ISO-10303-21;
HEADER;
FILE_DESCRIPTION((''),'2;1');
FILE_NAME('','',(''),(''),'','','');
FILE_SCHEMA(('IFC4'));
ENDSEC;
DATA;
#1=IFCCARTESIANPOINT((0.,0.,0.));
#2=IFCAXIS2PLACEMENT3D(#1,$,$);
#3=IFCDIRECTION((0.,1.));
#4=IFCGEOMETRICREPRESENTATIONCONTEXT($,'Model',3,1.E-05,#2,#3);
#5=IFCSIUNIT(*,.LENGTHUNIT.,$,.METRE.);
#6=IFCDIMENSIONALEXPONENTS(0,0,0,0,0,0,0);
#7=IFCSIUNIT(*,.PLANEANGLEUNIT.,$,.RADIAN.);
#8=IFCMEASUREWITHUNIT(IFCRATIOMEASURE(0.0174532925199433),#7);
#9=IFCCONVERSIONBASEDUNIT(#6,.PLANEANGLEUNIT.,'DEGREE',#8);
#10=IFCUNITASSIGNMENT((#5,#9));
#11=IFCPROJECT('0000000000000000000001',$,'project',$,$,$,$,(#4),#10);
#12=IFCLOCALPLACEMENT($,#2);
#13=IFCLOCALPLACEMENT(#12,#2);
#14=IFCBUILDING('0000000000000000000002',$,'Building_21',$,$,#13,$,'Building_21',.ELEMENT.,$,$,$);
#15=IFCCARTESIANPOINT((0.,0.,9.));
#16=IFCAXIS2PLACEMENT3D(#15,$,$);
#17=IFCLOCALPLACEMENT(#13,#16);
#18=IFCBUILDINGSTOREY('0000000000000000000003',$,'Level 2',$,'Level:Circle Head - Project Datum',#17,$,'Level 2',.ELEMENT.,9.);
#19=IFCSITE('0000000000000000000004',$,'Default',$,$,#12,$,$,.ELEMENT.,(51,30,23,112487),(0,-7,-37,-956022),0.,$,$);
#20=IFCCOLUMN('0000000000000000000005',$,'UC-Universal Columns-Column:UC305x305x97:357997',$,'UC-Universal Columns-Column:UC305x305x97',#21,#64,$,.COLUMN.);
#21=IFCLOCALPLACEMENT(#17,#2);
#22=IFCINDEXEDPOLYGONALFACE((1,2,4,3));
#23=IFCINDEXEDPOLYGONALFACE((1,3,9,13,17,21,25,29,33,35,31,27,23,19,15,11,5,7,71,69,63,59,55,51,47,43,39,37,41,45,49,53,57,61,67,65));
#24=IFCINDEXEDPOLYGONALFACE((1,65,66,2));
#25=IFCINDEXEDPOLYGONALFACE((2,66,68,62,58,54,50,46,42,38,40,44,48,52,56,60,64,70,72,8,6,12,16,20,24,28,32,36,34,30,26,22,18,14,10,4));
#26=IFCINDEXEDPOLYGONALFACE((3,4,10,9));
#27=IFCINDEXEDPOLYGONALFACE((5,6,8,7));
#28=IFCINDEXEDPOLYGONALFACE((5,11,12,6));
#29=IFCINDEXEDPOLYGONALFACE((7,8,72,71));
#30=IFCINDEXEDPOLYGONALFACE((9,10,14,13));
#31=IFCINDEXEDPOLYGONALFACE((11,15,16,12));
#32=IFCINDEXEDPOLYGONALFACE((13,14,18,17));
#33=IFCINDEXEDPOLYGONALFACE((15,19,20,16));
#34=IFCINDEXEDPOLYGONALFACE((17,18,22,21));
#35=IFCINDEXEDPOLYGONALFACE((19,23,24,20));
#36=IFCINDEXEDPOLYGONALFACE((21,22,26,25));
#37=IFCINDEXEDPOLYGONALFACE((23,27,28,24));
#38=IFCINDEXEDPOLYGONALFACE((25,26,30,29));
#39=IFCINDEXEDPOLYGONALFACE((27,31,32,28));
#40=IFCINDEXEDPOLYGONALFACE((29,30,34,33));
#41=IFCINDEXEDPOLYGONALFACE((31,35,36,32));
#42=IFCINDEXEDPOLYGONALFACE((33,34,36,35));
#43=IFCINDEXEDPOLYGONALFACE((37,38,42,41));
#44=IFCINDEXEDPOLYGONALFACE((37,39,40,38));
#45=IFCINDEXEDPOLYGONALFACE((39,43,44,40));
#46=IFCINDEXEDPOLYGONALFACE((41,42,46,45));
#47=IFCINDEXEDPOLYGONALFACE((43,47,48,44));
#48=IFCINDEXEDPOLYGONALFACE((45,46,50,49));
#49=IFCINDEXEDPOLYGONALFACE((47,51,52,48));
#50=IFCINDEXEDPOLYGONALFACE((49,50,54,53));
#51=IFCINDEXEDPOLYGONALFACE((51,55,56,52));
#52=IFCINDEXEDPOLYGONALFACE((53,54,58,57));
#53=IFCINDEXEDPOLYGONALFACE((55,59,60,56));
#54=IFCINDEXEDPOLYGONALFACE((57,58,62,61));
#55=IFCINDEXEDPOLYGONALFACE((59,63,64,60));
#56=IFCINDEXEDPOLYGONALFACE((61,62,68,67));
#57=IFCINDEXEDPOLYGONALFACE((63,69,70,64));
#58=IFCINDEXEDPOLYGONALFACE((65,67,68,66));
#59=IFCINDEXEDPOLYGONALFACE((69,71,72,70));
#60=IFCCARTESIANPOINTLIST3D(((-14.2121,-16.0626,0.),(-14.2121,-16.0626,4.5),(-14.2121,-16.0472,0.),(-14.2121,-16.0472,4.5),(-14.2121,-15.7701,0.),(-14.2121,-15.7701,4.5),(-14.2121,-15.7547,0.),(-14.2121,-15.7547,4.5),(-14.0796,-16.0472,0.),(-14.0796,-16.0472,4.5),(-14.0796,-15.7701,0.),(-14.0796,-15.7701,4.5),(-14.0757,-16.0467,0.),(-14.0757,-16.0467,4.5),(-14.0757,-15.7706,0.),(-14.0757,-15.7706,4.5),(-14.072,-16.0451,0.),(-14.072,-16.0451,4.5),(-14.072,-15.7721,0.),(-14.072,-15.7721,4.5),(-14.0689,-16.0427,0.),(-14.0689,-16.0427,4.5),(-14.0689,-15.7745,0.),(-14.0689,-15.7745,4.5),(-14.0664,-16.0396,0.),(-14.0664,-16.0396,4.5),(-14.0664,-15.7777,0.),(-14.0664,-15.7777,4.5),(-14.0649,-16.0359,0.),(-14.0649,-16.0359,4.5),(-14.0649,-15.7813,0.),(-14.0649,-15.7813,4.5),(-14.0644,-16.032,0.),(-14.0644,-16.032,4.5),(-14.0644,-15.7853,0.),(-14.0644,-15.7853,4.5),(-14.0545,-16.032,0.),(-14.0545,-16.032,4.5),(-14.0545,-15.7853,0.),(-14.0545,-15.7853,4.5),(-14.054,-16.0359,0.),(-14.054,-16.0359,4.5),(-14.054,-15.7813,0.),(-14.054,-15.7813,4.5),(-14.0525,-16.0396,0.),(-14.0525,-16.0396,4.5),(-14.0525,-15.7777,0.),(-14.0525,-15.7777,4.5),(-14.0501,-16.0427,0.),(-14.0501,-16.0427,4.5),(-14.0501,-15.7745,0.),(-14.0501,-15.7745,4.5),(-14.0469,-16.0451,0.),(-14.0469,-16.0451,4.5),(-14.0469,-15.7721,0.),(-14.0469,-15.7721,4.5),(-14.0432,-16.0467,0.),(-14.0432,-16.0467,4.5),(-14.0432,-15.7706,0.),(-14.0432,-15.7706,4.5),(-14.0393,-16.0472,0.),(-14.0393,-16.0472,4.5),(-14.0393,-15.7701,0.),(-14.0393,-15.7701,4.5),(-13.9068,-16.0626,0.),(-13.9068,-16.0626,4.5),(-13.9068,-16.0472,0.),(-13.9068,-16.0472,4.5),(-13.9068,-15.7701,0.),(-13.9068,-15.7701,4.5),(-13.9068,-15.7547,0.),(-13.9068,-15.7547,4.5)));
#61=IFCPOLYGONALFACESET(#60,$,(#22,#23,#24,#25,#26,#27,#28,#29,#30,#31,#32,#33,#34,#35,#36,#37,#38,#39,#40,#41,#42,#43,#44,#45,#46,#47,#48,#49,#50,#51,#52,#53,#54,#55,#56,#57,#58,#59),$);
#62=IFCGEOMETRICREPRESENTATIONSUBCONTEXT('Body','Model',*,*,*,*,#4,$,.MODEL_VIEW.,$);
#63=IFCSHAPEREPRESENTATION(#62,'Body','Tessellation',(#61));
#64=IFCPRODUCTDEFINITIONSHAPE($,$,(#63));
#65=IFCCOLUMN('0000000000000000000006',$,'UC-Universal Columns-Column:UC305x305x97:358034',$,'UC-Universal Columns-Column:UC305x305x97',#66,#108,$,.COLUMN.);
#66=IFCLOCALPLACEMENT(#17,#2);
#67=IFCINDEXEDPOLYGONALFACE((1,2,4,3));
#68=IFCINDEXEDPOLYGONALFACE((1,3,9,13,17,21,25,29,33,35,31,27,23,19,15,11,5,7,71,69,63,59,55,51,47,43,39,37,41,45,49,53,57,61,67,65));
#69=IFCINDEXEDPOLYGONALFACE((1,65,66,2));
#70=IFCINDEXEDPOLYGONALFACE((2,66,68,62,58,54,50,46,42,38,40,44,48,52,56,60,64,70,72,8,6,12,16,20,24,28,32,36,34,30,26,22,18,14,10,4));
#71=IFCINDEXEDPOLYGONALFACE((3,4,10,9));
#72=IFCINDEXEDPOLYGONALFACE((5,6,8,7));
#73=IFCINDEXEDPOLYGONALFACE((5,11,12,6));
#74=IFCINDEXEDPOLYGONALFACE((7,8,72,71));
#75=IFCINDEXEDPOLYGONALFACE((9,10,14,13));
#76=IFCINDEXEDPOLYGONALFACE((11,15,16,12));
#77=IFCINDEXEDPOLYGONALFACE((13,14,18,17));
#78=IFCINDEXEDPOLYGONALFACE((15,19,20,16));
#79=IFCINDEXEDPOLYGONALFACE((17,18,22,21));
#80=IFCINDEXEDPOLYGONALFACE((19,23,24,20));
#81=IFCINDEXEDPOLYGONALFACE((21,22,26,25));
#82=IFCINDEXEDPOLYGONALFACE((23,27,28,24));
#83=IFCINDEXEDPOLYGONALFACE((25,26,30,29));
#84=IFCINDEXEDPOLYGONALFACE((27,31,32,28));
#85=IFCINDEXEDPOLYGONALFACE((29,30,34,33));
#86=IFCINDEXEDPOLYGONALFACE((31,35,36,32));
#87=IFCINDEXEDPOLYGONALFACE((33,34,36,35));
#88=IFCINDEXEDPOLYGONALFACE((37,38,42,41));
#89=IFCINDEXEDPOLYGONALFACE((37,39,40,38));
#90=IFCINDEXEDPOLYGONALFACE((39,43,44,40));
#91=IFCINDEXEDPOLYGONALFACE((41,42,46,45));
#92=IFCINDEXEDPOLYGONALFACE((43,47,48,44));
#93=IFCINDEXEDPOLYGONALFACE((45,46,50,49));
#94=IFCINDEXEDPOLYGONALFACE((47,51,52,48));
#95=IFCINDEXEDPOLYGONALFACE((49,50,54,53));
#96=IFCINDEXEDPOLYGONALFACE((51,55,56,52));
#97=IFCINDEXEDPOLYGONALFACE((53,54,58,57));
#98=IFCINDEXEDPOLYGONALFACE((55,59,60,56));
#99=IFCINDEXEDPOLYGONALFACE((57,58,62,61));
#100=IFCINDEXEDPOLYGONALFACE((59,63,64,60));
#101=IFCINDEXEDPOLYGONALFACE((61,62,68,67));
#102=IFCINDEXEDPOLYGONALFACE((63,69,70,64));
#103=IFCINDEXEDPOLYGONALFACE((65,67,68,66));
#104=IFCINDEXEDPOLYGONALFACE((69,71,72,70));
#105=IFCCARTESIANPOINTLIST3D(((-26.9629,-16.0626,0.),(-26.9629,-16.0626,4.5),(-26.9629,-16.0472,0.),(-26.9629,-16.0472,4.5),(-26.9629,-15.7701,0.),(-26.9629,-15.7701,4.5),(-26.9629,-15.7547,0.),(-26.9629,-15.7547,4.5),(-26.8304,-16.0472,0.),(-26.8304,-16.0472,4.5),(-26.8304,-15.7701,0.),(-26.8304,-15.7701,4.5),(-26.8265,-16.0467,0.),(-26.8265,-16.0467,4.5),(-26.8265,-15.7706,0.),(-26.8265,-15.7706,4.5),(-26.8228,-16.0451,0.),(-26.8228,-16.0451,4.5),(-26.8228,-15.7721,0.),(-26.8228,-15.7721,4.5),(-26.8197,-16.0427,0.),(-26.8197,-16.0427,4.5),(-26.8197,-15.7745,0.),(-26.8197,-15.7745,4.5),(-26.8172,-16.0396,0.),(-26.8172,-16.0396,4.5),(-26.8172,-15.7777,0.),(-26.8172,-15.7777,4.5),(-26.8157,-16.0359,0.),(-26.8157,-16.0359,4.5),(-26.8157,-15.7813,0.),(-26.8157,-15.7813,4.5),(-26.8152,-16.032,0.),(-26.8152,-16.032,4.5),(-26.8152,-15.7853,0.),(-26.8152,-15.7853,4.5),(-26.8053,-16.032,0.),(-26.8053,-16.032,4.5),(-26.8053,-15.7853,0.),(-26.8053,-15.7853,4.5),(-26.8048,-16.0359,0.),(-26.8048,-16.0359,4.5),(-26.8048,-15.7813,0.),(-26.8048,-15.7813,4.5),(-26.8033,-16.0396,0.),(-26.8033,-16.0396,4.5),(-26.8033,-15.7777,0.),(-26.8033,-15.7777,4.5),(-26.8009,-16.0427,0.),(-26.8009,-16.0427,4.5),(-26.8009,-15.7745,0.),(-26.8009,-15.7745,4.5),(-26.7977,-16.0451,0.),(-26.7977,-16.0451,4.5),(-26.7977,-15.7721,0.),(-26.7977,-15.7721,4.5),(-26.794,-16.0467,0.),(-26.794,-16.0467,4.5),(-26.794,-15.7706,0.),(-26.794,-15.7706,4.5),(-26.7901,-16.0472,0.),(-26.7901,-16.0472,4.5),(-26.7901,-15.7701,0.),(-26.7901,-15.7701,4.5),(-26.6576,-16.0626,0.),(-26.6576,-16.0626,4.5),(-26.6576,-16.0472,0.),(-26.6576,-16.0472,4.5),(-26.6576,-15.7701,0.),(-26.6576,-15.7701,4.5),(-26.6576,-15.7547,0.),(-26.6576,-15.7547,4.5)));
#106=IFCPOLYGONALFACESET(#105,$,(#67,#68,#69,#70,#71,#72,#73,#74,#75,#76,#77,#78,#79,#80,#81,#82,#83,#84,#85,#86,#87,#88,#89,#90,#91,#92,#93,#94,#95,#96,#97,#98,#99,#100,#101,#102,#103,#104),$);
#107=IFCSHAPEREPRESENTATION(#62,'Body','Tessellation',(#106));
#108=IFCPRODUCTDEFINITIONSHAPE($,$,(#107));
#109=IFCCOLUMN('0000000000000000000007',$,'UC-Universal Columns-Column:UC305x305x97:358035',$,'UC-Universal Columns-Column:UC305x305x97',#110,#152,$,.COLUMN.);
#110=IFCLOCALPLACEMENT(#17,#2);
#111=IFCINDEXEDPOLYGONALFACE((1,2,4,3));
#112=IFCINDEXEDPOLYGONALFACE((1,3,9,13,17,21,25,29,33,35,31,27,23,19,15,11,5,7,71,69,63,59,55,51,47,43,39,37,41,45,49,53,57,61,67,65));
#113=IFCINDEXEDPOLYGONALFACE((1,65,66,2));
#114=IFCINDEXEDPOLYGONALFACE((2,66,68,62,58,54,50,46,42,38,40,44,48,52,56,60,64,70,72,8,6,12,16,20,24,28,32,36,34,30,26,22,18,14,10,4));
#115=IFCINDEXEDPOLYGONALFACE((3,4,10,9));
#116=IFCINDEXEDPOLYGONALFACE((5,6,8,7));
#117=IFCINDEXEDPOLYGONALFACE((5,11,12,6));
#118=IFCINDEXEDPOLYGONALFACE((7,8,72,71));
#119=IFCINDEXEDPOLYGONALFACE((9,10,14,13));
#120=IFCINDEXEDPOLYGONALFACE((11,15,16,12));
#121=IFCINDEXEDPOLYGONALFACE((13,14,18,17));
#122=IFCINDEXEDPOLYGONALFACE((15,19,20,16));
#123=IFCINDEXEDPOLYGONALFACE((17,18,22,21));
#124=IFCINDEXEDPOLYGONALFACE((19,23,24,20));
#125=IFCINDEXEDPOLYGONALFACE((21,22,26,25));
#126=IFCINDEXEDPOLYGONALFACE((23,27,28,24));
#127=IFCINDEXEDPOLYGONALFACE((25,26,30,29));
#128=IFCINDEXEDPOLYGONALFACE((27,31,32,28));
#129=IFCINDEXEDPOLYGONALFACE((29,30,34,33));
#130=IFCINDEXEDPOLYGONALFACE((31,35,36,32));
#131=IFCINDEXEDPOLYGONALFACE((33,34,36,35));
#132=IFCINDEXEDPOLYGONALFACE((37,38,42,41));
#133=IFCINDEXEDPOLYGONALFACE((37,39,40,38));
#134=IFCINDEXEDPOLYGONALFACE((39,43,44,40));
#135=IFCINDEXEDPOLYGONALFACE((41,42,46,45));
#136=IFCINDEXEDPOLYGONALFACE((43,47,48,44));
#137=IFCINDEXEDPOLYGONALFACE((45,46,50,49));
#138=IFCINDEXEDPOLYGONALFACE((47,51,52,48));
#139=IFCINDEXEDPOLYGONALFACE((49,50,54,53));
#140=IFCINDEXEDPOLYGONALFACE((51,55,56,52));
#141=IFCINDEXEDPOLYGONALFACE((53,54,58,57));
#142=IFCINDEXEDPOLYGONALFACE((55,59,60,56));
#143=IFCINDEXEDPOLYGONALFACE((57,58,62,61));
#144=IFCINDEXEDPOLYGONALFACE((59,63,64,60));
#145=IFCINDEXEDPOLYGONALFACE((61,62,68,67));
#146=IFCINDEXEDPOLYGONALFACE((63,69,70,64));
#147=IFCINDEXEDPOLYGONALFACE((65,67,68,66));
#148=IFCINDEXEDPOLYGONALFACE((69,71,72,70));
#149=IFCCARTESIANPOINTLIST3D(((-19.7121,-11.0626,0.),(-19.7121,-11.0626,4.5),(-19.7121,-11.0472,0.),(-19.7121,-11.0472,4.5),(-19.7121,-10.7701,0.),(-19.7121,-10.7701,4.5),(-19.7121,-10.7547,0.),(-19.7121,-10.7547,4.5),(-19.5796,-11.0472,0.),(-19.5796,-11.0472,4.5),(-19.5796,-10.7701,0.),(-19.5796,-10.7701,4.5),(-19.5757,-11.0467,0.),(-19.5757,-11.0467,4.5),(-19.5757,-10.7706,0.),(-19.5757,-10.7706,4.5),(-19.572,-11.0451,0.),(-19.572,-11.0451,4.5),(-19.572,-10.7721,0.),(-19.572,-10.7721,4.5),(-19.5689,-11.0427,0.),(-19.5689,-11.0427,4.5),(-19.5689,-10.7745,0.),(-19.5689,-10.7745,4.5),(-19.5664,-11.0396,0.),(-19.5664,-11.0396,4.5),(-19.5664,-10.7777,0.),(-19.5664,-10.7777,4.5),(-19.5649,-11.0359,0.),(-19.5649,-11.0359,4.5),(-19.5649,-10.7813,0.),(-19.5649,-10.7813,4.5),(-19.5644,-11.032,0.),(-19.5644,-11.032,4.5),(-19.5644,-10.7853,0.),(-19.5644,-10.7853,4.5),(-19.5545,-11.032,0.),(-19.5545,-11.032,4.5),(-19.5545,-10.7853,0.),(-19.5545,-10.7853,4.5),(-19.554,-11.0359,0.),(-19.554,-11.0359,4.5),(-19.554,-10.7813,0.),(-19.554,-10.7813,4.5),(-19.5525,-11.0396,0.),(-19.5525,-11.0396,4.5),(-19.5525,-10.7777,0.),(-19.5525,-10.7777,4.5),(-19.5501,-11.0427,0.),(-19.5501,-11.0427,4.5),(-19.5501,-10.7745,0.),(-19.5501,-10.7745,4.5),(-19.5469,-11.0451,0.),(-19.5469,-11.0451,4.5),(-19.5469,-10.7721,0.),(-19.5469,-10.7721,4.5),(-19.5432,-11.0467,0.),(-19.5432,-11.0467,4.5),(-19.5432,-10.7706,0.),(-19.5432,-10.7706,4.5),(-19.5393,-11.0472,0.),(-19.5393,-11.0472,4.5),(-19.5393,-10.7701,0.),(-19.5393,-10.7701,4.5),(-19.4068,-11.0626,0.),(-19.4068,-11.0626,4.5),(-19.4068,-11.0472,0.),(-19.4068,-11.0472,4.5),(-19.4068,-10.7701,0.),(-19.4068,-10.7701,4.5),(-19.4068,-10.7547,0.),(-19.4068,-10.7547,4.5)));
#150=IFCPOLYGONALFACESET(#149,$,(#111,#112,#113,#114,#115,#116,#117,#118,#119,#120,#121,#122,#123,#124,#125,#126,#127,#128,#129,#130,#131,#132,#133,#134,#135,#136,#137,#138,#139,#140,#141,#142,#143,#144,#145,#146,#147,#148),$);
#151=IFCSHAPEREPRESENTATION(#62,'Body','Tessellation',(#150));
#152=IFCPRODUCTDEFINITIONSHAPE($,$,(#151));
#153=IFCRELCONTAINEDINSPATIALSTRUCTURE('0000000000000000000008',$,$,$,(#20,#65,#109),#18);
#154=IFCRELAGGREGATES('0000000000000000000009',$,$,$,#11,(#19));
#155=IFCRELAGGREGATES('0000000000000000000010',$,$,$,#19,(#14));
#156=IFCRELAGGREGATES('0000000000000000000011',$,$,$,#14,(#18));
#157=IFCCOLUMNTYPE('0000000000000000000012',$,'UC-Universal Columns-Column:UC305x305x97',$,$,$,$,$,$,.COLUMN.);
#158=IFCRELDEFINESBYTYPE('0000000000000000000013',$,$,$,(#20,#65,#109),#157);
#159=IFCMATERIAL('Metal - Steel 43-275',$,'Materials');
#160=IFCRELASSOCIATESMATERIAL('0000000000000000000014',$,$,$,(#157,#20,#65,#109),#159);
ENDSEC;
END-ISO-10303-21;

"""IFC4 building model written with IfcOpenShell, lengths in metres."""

from ifc_helpers import new_model, entity, si_unit, converted_unit, direction, frame, frame_2d, origin, place, context, subcontext, project, spatial, polyline, circle_curve, parameter, trimmed, segment, composite_curve, i_section, outline, extrude, source, transform, mapped, material, material_profile, profile_set, profile_usage, type_object, type_shapes, element, save


model = new_model("IFC4")

# Units and contexts
model_context = context("Model", 3, precision=1e-05, world=origin(), true_north=direction((0.0, 1.0)))
body_context = subcontext(model_context, "Body", "Model", "MODEL_VIEW")
ifc_project = project(units=[si_unit("LENGTHUNIT", "METRE"), converted_unit("PLANEANGLEUNIT", "DEGREE", entity("IfcRatioMeasure", 0.0174532925199433), si_unit("PLANEANGLEUNIT", "RADIAN"), dimensions=[0, 0, 0, 0, 0, 0, 0])], contexts=[model_context])

# Site, building, storey
site_placement = place(None, origin())
site = spatial("IfcSite", under=ifc_project, at=site_placement, Name="Default", CompositionType="ELEMENT", RefLatitude=(51, 30, 23, 112487), RefLongitude=(0, -7, -37, -956022), RefElevation=0.0)
building_placement = place(site_placement, origin())
building = spatial("IfcBuilding", under=site, at=building_placement, Name="Building_21", LongName="Building_21", CompositionType="ELEMENT")
storey_placement = place(building_placement, frame((0.0, 0.0, 9.0)))
storey = spatial("IfcBuildingStorey", under=building, at=storey_placement, Name="Level 2", ObjectType="Level:Circle Head - Project Datum", LongName="Level 2", CompositionType="ELEMENT", Elevation=9.0)

# Columns
ifc_material_1 = material(Name="Metal - Steel 43-275", Category="Materials")
ifc_material_profile_1 = material_profile(ifc_material_1, outline(composite_curve([segment(polyline([(-0.1527, 0.154, 0.0), (0.1527, 0.154, 0.0)]), True, "CONTINUOUS"), segment(polyline([(0.1527, 0.154, 0.0), (0.1527, 0.1386, 0.0)]), True, "CONTINUOUS"), segment(polyline([(0.1527, 0.1386, 0.0), (0.0201, 0.1386, 0.0)]), True, "CONTINUOUS"), segment(trimmed(circle_curve(frame((0.0201, 0.1234, 0.0)), 0.0152), [parameter(90.0)], [parameter(180.0)], True, "PARAMETER"), True, "CONTINUOUS"), segment(polyline([(0.0049, 0.1234, 0.0), (0.0049, -0.1234, 0.0)]), True, "CONTINUOUS"), segment(trimmed(circle_curve(frame((0.0201, -0.1234, 0.0)), 0.0152), [parameter(180.0)], [parameter(270.0)], True, "PARAMETER"), True, "CONTINUOUS"), segment(polyline([(0.0201, -0.1386, 0.0), (0.1527, -0.1386, 0.0)]), True, "CONTINUOUS"), segment(polyline([(0.1527, -0.1386, 0.0), (0.1527, -0.154, 0.0)]), True, "CONTINUOUS"), segment(polyline([(0.1527, -0.154, 0.0), (-0.1527, -0.154, 0.0)]), True, "CONTINUOUS"), segment(polyline([(-0.1527, -0.154, 0.0), (-0.1527, -0.1386, 0.0)]), True, "CONTINUOUS"), segment(polyline([(-0.1527, -0.1386, 0.0), (-0.0201, -0.1386, 0.0)]), True, "CONTINUOUS"), segment(trimmed(circle_curve(frame((-0.0201, -0.1234, 0.0)), 0.0152), [parameter(270.0)], [parameter(0.0)], True, "PARAMETER"), True, "CONTINUOUS"), segment(polyline([(-0.0049, -0.1234, 0.0), (-0.005, 0.1234, 0.0)]), True, "CONTINUOUS"), segment(trimmed(circle_curve(frame((-0.0201, 0.1234, 0.0)), 0.0152), [parameter(0.0)], [parameter(90.0)], True, "PARAMETER"), True, "CONTINUOUS"), segment(polyline([(-0.0201, 0.1386, 0.0), (-0.1527, 0.1386, 0.0)]), True, "CONTINUOUS"), segment(polyline([(-0.1527, 0.1386, 0.0), (-0.1527, 0.154, 0.0)]), True, "CONTINUOUS")], self_intersect=False), kind="CURVE"), Name="UC305x305x97")
ifc_material_profile_2 = material_profile(ifc_material_1, outline(composite_curve([segment(polyline([(0.1527, 0.154, 0.0), (0.1527, 0.1386, 0.0)]), True, "CONTINUOUS"), segment(polyline([(0.1527, 0.1386, 0.0), (0.0049, 0.1386, 0.0)]), True, "CONTINUOUS"), segment(polyline([(0.0049, 0.1386, 0.0), (0.0049, -0.1386, 0.0)]), True, "CONTINUOUS"), segment(polyline([(0.0049, -0.1386, 0.0), (0.1527, -0.1386, 0.0)]), True, "CONTINUOUS"), segment(polyline([(0.1527, -0.1386, 0.0), (0.1527, -0.154, 0.0)]), True, "CONTINUOUS"), segment(polyline([(0.1527, -0.154, 0.0), (-0.1527, -0.154, 0.0)]), True, "CONTINUOUS"), segment(polyline([(-0.1527, -0.154, 0.0), (-0.1527, -0.1386, 0.0)]), True, "CONTINUOUS"), segment(polyline([(-0.1527, -0.1386, 0.0), (-0.005, -0.1386, 0.0)]), True, "CONTINUOUS"), segment(polyline([(-0.005, -0.1386, 0.0), (-0.005, 0.1386, 0.0)]), True, "CONTINUOUS"), segment(polyline([(-0.005, 0.1386, 0.0), (-0.1527, 0.1386, 0.0)]), True, "CONTINUOUS"), segment(polyline([(-0.1527, 0.1386, 0.0), (-0.1527, 0.154, 0.0)]), True, "CONTINUOUS"), segment(polyline([(-0.1527, 0.154, 0.0), (0.1527, 0.154, 0.0)]), True, "CONTINUOUS")], self_intersect=False), kind="CURVE"), Name="UC305x305x97")
ifc_profile_set_1 = profile_set([ifc_material_profile_1, ifc_material_profile_2], Name="UC305x305x97")
ifc_profile_usage_1 = profile_usage(ifc_profile_set_1)
column_type = type_object("IfcColumnType", Name="UC-Universal Columns-Column:UC305x305x97", PredefinedType="COLUMN", material=ifc_profile_set_1)
shared_shape_1 = source(origin(), body_context, "Body", "SweptSolid", [
    extrude(i_section(OverallWidth=0.3053, OverallDepth=0.3079, WebThickness=0.0099, FlangeThickness=0.0154, FilletRadius=0.0152, at=frame_2d((0.0, 0.0), x_axis=(0.0, 1.0))), frame((0.0, 0.0, 9.0), z_axis=(0.0, 0.0, 1.0), x_axis=(0.0, -1.0, 0.0)), (0.0, 0.0, 1.0), 4.5),
])
type_shapes(column_type, [shared_shape_1])
column_1_placement = place(storey_placement, frame((-14.0595, -15.9086, -9.0)))
element("IfcColumn", 1, at=column_1_placement, inside=storey, type_object=column_type, material=ifc_profile_usage_1, Name="UC-Universal Columns-Column:UC305x305x97:357997", ObjectType="UC-Universal Columns-Column:UC305x305x97", PredefinedType="COLUMN", context=body_context, shape_type="MappedRepresentation", body=[
    mapped(shared_shape_1, transform((0.0, 0.0, 0.0), scale=1.0)),
])
ifc_profile_usage_2 = profile_usage(ifc_profile_set_1)
column_2_placement = place(storey_placement, frame((-26.8103, -15.9086, -9.0)))
element("IfcColumn", 2, at=column_2_placement, inside=storey, type_object=column_type, material=ifc_profile_usage_2, Name="UC-Universal Columns-Column:UC305x305x97:358034", ObjectType="UC-Universal Columns-Column:UC305x305x97", PredefinedType="COLUMN", context=body_context, shape_type="MappedRepresentation", body=[
    mapped(shared_shape_1, transform((0.0, 0.0, 0.0), scale=1.0)),
])
ifc_profile_usage_3 = profile_usage(ifc_profile_set_1)
column_3_placement = place(storey_placement, frame((-19.5595, -10.9086, -9.0)))
element("IfcColumn", 3, at=column_3_placement, inside=storey, type_object=column_type, material=ifc_profile_usage_3, Name="UC-Universal Columns-Column:UC305x305x97:358035", ObjectType="UC-Universal Columns-Column:UC305x305x97", PredefinedType="COLUMN", context=body_context, shape_type="MappedRepresentation", body=[
    mapped(shared_shape_1, transform((0.0, 0.0, 0.0), scale=1.0)),
])

save(model, "model.ifc")
